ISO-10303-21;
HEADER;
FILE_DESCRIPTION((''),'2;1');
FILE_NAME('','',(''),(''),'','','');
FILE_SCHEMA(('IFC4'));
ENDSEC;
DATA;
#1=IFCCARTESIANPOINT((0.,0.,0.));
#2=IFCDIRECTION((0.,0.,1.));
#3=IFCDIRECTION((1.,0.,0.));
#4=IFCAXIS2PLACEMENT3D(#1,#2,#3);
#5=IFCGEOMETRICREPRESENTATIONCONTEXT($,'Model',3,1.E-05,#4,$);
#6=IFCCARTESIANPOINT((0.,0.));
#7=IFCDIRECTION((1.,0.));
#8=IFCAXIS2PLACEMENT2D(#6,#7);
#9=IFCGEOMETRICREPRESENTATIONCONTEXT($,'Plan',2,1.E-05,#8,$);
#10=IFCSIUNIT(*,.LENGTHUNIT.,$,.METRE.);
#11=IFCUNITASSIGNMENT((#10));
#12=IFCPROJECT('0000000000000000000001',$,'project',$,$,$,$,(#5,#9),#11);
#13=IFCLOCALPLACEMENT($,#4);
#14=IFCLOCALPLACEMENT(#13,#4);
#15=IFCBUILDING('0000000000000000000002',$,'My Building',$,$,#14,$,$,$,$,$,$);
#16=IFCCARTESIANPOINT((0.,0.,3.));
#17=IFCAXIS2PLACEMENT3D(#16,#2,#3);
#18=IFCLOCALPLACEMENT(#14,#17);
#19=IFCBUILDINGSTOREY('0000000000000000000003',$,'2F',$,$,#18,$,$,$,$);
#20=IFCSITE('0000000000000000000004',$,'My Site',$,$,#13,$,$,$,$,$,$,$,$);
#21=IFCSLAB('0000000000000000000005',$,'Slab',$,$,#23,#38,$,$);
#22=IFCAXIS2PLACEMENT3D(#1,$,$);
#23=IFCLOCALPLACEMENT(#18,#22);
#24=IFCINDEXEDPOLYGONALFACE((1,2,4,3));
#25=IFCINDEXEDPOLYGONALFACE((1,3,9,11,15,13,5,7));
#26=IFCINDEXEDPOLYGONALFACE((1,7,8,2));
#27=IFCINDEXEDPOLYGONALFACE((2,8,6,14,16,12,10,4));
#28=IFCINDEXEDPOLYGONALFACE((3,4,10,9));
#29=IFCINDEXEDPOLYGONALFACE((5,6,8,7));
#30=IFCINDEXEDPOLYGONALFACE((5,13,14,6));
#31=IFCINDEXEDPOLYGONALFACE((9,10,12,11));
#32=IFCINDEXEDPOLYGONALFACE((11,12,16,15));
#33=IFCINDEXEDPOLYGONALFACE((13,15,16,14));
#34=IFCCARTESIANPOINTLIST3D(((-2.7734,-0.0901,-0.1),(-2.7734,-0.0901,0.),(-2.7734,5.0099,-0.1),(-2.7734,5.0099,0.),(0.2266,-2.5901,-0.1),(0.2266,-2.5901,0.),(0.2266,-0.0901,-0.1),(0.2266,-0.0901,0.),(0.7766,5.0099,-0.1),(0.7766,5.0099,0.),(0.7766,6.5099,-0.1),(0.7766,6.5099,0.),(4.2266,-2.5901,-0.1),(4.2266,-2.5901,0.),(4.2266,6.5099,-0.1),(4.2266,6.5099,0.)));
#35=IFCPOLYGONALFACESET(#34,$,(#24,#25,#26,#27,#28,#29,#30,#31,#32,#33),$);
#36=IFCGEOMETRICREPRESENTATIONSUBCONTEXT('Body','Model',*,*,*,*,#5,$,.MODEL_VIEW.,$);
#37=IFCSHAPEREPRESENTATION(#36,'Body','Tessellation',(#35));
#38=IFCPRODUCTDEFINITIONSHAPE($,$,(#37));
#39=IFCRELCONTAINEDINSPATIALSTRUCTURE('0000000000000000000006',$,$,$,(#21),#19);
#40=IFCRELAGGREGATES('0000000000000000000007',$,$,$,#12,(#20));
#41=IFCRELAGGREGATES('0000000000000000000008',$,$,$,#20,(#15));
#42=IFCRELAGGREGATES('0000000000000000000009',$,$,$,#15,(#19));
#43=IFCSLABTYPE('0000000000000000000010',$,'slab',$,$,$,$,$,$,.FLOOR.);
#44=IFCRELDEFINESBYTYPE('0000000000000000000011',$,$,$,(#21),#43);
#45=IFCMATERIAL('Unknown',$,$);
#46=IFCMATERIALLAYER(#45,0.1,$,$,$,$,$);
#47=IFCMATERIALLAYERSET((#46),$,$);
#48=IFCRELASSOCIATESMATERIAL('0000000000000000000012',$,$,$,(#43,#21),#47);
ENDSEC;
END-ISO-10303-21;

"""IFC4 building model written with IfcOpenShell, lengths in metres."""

from ifc_helpers import new_model, si_unit, frame, origin_with_axes, origin_2d_with_axis, place, context, subcontext, project, spatial, indexed_curve, outline, extrude, material, layer, layer_set, layer_usage, type_object, element, save


model = new_model("IFC4")

# Units and contexts
model_context = context("Model", 3, precision=1e-05, world=origin_with_axes())
plan_context = context("Plan", 2, precision=1e-05, world=origin_2d_with_axis())
body_context = subcontext(model_context, "Body", "Model", "MODEL_VIEW")
ifc_project = project(units=[si_unit("LENGTHUNIT", "METRE")], contexts=[model_context, plan_context])

# Site, building, storey
site_placement = place(None, origin_with_axes())
site = spatial("IfcSite", under=ifc_project, at=site_placement, Name="My Site")
building_placement = place(site_placement, origin_with_axes())
building = spatial("IfcBuilding", under=site, at=building_placement, Name="My Building")
storey_placement = place(building_placement, frame((0.0, 0.0, 3.0), z_axis=(0.0, 0.0, 1.0), x_axis=(1.0, 0.0, 0.0)))
storey = spatial("IfcBuildingStorey", under=building, at=storey_placement, Name="2F")

# Slab
ifc_material = material(Name="Unknown")
ifc_layer = layer(ifc_material, 0.1)
ifc_layer_set = layer_set([ifc_layer])
ifc_layer_usage = layer_usage(ifc_layer_set, "AXIS3", "POSITIVE", -0.1)
slab_type = type_object("IfcSlabType", Name="slab", PredefinedType="FLOOR", material=ifc_layer_set)
slab_placement = place(storey_placement, frame((4.2266, 6.5099, 0.0), z_axis=(0.0, 0.0, 1.0), x_axis=(1.0, 0.0, 0.0)))
element("IfcSlab", 1, at=slab_placement, inside=storey, type_object=slab_type, material=ifc_layer_usage, Name="Slab", context=body_context, shape_type="SweptSolid", body=[
    extrude(outline(indexed_curve([(0.0, 0.0), (-3.45, 0.0), (-3.45, -1.5), (-7.0, -1.5), (-7.0, -6.6), (-4.0, -6.6), (-4.0, -9.1), (0.0, -9.1), (0.0, 0.0)])), frame((0.0, 0.0, -0.1), z_axis=(0.0, 0.0, 1.0), x_axis=(1.0, 0.0, 0.0)), (0.0, 0.0, 1.0), 0.1),
])

save(model, "model.ifc")
